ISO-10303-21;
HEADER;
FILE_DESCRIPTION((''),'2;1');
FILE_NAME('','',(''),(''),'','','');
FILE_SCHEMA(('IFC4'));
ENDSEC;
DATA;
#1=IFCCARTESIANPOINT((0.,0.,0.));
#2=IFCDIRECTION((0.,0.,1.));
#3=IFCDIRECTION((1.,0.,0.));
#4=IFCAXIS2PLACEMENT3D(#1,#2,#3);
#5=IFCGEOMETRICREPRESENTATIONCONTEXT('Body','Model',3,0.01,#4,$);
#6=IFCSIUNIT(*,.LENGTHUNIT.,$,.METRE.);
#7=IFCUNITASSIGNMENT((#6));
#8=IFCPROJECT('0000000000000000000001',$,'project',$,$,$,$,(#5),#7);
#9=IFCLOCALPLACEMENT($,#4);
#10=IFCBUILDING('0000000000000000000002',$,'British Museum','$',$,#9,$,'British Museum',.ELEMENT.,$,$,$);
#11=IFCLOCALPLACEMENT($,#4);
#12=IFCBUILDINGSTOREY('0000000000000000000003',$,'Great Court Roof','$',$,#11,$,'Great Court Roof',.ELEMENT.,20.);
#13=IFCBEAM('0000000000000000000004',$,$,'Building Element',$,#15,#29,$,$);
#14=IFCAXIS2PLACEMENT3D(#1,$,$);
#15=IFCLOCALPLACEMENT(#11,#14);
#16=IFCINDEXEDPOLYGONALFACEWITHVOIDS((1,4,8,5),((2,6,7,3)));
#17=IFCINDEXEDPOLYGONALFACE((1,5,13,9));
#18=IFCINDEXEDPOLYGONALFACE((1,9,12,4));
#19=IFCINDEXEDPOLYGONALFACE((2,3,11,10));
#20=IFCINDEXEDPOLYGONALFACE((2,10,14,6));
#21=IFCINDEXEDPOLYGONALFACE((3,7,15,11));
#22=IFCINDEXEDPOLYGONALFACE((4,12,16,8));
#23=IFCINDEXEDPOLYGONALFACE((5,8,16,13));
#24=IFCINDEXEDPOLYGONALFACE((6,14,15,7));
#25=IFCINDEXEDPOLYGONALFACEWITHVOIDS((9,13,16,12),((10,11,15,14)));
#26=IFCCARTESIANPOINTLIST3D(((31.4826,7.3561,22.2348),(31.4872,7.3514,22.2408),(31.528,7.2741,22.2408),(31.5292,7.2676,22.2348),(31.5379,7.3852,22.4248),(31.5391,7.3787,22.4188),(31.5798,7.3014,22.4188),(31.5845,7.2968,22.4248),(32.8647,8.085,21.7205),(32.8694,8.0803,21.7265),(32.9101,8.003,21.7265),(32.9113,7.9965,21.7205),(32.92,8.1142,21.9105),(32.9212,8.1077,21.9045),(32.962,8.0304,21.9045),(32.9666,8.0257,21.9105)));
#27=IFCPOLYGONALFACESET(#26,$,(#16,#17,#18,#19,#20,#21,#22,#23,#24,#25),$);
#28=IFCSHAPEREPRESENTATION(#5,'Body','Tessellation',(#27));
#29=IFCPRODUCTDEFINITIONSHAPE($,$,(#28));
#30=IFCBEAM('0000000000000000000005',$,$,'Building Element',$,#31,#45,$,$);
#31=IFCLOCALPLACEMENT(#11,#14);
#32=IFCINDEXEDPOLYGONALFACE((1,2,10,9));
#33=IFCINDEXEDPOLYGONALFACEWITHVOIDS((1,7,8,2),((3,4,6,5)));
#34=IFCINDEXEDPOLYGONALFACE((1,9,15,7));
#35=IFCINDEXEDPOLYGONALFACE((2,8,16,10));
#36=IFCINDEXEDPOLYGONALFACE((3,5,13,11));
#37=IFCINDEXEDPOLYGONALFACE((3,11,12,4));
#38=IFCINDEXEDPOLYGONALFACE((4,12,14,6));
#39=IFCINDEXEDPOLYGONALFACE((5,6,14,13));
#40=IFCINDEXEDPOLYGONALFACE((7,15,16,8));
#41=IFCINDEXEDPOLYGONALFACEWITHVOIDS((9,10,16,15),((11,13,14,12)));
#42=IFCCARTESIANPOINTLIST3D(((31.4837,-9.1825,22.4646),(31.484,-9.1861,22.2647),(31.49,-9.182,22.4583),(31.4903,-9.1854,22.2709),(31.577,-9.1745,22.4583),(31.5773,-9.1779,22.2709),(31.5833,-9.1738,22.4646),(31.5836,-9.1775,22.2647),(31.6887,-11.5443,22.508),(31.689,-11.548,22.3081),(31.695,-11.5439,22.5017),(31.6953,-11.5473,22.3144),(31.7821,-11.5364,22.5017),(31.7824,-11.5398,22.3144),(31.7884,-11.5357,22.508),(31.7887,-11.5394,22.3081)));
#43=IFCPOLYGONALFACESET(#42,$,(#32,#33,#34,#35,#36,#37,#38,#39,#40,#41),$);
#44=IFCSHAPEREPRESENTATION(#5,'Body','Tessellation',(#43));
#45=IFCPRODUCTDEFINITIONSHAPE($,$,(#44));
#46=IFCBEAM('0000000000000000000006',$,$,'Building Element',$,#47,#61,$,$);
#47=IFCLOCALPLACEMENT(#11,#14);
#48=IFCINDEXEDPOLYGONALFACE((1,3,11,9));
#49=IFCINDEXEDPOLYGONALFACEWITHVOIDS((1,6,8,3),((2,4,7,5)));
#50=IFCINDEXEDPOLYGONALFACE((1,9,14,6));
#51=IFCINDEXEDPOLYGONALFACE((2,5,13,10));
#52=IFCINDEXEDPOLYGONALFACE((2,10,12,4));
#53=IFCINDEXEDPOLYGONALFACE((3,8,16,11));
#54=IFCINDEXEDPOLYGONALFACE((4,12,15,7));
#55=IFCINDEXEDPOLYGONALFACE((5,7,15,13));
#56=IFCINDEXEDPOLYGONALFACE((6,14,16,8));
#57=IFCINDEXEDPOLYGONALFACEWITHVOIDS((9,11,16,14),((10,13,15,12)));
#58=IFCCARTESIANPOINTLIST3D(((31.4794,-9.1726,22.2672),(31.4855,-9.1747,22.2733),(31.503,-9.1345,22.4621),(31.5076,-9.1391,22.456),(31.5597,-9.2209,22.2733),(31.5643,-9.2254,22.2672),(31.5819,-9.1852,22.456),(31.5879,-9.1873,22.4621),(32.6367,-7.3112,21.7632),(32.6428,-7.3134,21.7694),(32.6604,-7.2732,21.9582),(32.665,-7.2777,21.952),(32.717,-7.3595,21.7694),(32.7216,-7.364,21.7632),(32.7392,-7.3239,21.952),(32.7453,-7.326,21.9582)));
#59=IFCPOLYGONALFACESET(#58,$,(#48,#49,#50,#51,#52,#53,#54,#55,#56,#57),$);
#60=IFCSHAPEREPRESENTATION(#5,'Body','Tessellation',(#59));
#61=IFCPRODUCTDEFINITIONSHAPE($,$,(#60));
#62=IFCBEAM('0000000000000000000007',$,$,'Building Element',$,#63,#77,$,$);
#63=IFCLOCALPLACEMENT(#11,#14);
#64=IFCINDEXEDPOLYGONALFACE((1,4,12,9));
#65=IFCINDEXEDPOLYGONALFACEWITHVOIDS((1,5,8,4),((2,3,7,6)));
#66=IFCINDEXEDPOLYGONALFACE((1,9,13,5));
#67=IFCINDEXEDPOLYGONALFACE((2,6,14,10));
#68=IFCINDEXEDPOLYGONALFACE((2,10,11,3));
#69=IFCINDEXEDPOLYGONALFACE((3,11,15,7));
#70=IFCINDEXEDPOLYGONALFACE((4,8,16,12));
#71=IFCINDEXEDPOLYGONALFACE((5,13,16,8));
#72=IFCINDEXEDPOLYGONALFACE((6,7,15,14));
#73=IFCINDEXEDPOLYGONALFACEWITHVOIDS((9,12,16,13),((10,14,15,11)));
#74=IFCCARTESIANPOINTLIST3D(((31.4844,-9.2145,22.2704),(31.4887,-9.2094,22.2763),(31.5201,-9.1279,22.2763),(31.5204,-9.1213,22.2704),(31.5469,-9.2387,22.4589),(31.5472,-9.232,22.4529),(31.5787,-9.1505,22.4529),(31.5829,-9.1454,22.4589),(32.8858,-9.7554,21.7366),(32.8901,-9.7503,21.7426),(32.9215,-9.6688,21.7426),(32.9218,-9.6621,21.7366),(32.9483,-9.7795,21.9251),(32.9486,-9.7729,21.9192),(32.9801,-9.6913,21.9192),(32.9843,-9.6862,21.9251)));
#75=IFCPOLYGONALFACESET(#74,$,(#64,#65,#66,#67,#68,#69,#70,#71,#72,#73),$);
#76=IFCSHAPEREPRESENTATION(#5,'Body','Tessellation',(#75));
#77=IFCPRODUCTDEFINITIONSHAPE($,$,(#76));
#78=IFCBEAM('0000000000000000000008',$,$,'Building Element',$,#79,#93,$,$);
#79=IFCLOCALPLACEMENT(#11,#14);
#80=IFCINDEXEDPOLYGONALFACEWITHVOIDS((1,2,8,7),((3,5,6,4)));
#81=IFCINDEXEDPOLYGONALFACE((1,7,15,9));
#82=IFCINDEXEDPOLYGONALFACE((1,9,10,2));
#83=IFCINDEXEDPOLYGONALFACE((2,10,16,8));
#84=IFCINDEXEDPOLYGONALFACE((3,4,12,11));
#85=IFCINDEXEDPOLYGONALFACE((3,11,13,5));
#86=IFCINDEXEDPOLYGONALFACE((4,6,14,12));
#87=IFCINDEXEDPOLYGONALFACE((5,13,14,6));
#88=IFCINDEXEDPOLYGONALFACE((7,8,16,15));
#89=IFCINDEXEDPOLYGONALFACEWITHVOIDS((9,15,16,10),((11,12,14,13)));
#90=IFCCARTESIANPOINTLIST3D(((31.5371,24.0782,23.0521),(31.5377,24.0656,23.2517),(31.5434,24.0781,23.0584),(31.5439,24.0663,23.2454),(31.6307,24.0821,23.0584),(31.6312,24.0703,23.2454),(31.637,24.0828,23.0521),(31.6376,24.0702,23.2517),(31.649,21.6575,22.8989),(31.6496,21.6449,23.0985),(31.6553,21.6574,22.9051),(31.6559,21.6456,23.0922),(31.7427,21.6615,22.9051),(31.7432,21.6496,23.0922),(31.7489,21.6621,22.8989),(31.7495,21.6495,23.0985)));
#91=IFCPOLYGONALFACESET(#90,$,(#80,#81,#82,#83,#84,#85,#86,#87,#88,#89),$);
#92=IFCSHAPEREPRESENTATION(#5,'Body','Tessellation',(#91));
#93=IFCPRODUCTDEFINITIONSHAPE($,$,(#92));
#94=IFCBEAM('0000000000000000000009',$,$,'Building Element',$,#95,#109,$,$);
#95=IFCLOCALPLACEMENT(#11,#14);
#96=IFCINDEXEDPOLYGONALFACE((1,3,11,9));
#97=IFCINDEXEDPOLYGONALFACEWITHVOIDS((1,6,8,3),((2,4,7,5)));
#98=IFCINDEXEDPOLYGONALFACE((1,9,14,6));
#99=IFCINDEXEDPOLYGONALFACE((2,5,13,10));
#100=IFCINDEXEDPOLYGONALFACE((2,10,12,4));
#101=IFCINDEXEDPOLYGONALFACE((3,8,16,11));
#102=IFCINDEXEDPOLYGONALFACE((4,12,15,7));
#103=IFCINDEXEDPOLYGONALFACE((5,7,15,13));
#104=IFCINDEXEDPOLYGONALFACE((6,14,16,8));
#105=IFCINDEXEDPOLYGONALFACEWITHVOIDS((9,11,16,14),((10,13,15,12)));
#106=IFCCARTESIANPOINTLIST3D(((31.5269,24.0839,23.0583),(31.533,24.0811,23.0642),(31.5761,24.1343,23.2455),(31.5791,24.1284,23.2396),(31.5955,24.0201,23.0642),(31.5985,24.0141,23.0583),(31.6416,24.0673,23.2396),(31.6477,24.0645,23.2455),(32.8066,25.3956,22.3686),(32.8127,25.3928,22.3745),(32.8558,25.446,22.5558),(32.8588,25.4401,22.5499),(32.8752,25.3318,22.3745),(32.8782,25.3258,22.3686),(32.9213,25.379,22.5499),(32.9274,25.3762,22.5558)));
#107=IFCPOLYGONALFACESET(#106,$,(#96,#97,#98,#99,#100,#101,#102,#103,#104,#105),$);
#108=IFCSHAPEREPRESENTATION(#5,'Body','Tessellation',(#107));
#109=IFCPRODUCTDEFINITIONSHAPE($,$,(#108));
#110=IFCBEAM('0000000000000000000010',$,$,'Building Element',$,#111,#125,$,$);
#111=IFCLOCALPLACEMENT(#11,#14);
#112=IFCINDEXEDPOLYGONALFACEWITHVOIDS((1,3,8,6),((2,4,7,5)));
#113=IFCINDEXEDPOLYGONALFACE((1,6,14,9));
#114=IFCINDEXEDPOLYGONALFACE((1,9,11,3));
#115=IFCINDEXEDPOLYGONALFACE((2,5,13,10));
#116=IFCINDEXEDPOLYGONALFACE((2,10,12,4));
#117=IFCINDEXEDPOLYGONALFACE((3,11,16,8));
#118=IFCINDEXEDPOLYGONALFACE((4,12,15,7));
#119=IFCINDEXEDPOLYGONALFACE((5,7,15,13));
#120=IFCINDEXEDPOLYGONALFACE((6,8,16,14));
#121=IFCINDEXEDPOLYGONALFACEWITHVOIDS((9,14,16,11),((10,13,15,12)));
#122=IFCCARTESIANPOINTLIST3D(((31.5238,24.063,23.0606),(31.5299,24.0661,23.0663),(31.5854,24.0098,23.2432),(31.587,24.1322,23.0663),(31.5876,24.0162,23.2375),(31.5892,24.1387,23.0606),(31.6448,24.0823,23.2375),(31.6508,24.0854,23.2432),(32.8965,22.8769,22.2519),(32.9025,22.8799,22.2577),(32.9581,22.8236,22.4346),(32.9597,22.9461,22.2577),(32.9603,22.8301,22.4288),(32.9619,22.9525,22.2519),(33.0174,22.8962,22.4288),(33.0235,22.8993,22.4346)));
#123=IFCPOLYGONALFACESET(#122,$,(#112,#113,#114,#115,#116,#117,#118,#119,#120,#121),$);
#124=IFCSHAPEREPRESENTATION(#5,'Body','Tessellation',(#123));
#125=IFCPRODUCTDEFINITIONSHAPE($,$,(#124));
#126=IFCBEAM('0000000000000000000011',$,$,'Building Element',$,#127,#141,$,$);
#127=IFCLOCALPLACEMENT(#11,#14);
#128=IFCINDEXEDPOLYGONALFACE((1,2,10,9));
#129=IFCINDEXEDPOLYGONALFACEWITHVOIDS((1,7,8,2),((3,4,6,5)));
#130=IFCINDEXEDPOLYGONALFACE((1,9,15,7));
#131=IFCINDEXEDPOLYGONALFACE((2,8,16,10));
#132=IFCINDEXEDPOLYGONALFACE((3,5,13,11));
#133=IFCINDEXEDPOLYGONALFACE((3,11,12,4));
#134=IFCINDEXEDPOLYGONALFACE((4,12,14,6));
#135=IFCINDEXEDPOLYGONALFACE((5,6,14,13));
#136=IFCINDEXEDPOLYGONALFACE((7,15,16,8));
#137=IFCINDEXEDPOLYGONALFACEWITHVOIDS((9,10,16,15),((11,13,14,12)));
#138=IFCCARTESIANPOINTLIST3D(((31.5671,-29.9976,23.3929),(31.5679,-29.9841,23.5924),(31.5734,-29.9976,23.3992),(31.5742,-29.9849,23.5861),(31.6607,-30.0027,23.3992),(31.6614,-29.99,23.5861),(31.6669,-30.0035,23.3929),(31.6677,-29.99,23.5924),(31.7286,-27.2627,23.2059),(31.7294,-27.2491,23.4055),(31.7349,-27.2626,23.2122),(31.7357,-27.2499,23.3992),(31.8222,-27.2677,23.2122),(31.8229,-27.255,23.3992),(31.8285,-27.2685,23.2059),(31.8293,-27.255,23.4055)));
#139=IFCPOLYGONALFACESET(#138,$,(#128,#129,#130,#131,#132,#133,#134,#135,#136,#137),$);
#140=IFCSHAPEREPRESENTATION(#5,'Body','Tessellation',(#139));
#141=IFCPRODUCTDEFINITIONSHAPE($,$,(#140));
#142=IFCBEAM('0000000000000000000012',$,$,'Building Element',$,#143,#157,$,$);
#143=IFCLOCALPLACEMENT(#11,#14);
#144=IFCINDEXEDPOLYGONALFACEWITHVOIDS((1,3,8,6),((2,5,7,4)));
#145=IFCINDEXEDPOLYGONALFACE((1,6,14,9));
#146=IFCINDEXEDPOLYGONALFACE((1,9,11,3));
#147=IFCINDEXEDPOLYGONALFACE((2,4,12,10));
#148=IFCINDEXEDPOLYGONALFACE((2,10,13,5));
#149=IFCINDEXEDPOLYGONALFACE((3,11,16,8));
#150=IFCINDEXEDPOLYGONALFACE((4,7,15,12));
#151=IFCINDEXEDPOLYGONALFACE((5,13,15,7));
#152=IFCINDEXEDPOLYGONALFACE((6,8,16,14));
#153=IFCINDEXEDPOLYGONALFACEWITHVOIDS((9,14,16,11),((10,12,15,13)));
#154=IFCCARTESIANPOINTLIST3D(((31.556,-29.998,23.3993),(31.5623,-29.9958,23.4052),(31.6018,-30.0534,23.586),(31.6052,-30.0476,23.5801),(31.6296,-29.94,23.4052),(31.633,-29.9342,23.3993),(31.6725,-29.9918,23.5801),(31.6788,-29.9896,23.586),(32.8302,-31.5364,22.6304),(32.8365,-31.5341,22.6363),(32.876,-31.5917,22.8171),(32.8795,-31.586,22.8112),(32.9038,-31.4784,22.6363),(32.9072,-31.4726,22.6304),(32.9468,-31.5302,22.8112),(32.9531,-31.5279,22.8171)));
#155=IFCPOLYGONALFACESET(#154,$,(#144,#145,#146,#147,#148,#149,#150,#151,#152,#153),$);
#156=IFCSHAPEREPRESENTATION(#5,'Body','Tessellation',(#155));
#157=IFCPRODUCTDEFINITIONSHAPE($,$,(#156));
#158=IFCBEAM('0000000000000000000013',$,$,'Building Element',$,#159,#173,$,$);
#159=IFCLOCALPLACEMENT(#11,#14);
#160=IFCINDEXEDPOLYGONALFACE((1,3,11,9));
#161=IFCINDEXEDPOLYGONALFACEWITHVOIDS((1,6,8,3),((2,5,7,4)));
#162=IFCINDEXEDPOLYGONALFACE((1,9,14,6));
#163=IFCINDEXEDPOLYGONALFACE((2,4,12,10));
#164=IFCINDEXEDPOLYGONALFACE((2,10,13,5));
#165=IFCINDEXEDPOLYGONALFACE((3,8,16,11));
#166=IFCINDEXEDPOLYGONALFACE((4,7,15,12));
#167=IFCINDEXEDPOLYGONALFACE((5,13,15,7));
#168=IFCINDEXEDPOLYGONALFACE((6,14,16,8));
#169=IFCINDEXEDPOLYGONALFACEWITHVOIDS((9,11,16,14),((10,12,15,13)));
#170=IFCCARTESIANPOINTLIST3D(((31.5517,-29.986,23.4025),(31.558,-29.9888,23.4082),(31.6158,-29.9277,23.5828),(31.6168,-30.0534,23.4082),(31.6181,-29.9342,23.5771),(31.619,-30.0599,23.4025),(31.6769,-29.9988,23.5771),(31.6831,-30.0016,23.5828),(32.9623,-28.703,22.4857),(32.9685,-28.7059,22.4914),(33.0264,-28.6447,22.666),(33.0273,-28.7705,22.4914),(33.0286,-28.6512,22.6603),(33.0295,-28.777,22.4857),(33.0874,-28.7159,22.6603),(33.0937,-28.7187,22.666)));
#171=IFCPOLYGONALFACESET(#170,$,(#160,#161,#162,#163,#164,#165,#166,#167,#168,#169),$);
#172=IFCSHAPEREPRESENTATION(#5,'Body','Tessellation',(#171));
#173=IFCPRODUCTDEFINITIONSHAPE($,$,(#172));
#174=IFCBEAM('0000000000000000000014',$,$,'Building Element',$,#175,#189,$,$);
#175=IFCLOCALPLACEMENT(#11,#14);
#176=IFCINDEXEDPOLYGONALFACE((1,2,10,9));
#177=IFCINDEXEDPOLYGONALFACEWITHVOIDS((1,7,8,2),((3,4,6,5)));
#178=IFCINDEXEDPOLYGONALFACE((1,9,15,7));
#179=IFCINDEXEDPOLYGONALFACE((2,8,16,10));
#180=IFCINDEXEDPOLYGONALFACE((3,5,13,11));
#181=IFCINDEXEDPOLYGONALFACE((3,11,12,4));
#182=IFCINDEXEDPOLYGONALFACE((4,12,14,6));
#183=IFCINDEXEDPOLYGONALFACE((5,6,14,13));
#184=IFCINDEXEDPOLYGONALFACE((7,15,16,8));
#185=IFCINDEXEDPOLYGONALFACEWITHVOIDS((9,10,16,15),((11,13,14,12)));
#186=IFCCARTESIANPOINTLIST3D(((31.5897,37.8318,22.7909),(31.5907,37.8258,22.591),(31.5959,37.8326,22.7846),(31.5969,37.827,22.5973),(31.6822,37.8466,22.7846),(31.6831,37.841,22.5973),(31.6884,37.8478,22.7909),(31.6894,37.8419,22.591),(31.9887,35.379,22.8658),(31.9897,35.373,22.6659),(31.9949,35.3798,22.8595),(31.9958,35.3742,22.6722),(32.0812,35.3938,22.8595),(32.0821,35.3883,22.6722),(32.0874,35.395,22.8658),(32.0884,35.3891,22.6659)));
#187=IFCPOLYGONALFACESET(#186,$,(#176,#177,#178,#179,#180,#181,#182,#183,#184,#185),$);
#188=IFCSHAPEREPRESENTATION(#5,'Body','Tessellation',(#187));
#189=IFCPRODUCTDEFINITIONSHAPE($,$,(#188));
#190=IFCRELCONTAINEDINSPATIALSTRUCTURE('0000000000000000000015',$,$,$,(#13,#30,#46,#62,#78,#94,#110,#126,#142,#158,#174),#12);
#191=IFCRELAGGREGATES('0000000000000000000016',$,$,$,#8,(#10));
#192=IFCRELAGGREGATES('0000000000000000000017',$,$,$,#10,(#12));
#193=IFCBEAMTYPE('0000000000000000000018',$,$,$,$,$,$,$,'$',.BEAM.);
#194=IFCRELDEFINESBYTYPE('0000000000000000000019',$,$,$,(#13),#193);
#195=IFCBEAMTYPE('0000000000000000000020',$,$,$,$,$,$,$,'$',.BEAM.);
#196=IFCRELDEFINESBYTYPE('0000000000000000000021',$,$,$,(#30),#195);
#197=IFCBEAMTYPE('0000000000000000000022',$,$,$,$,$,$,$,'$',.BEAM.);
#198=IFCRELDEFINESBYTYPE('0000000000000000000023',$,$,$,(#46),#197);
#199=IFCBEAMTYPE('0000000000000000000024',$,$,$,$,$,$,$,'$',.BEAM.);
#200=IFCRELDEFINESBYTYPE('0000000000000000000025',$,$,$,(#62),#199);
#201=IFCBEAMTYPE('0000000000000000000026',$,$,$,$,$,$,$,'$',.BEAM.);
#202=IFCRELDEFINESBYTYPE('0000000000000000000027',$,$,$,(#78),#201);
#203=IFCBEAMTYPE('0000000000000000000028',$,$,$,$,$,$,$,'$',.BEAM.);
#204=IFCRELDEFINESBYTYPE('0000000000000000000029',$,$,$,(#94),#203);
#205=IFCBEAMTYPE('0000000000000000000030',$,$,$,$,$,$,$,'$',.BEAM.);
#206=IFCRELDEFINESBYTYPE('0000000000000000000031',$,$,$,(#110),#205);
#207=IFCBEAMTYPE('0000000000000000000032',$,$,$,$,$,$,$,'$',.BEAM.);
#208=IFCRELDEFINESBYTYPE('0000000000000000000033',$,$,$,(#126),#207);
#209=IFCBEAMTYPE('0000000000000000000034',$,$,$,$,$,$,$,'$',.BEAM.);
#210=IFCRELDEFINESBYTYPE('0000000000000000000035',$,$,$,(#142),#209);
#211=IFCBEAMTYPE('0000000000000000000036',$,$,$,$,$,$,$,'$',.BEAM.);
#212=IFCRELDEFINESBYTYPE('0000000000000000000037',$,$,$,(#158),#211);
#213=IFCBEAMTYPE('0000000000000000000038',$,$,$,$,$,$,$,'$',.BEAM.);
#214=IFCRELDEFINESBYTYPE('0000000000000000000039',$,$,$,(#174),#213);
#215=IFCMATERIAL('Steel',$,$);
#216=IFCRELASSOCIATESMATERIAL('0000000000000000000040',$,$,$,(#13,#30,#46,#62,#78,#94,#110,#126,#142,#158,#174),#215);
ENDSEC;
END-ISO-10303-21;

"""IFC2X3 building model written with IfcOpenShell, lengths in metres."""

from ifc_helpers import new_model, si_unit, frame, origin_with_axes, origin_2d, place, context, project, spatial, hollow_rectangle, extrude, material, type_object, element, save


model = new_model("IFC2X3")

# Units and contexts
model_context = context("Model", 3, precision=0.01, world=origin_with_axes(), identifier="Body")
ifc_project = project(units=[si_unit("LENGTHUNIT", "METRE")], contexts=[model_context])

# Building, storey
building_placement = place(None, origin_with_axes())
building = spatial("IfcBuilding", under=ifc_project, at=building_placement, Name="British Museum", Description="$", LongName="British Museum", CompositionType="ELEMENT")
storey_placement = place(None, origin_with_axes())
storey = spatial("IfcBuildingStorey", under=building, at=storey_placement, Name="Great Court Roof", Description="$", LongName="Great Court Roof", CompositionType="ELEMENT", Elevation=20.0)

# Beams
ifc_material = material(Name="Steel")
beam_type_1 = type_object("IfcBeamType", ElementType="$", PredefinedType="BEAM")
beam_1_placement = place(None, origin_with_axes())
element("IfcBeam", 1, at=beam_1_placement, inside=storey, type_object=beam_type_1, material=ifc_material, Description="Building Element", context=model_context, shape_type="SweptSolid", body=[
    extrude(hollow_rectangle(XDim=0.1, YDim=0.2, WallThickness=0.0063, InnerFilletRadius=0.0, OuterFilletRadius=0.0, at=origin_2d()), frame((31.5335, 7.3264, 22.3298), z_axis=(0.84018, 0.443111, -0.31265), x_axis=(-0.466497, 0.884523, 0.0)), (0.0, 0.0, 1.0), 1.645),
])
beam_type_2 = type_object("IfcBeamType", ElementType="$", PredefinedType="BEAM")
beam_2_placement = place(None, origin_with_axes())
element("IfcBeam", 2, at=beam_2_placement, inside=storey, type_object=beam_type_2, material=ifc_material, Description="Building Element", context=model_context, shape_type="SweptSolid", body=[
    extrude(hollow_rectangle(XDim=0.1, YDim=0.2, WallThickness=0.0063, InnerFilletRadius=0.0, OuterFilletRadius=0.0, at=origin_2d()), frame((31.5337, -9.18, 22.3646), z_axis=(0.086476, -0.996086, 0.018315), x_axis=(0.996253, 0.086491, 0.0)), (0.0, 0.0, 1.0), 2.3712),
])
beam_type_3 = type_object("IfcBeamType", ElementType="$", PredefinedType="BEAM")
beam_3_placement = place(None, origin_with_axes())
element("IfcBeam", 3, at=beam_3_placement, inside=storey, type_object=beam_type_3, material=ifc_material, Description="Building Element", context=model_context, shape_type="SweptSolid", body=[
    extrude(hollow_rectangle(XDim=0.1, YDim=0.2, WallThickness=0.0063, InnerFilletRadius=0.0, OuterFilletRadius=0.0, at=origin_2d()), frame((31.5337, -9.18, 22.3646), z_axis=(0.514608, 0.827629, -0.224073), x_axis=(-0.849223, 0.528034, 0.0)), (0.0, 0.0, 1.0), 2.249),
])
beam_type_4 = type_object("IfcBeamType", ElementType="$", PredefinedType="BEAM")
beam_4_placement = place(None, origin_with_axes())
element("IfcBeam", 4, at=beam_4_placement, inside=storey, type_object=beam_type_4, material=ifc_material, Description="Building Element", context=model_context, shape_type="SweptSolid", body=[
    extrude(hollow_rectangle(XDim=0.1, YDim=0.2, WallThickness=0.0063, InnerFilletRadius=0.0, OuterFilletRadius=0.0, at=origin_2d()), frame((31.5337, -9.18, 22.3646), z_axis=(0.879086, -0.339272, -0.334817), x_axis=(0.360053, 0.932932, 0.0)), (0.0, 0.0, 1.0), 1.5942),
])
beam_type_5 = type_object("IfcBeamType", ElementType="$", PredefinedType="BEAM")
beam_5_placement = place(None, origin_with_axes())
element("IfcBeam", 5, at=beam_5_placement, inside=storey, type_object=beam_type_5, material=ifc_material, Description="Building Element", context=model_context, shape_type="SweptSolid", body=[
    extrude(hollow_rectangle(XDim=0.1, YDim=0.2, WallThickness=0.0063, InnerFilletRadius=0.0, OuterFilletRadius=0.0, at=origin_2d()), frame((31.5873, 24.0742, 23.1519), z_axis=(0.046107, -0.996941, -0.063107), x_axis=(0.998932, 0.046199, 0.0)), (0.0, 0.0, 1.0), 2.4281),
])
beam_type_6 = type_object("IfcBeamType", ElementType="$", PredefinedType="BEAM")
beam_6_placement = place(None, origin_with_axes())
element("IfcBeam", 6, at=beam_6_placement, inside=storey, type_object=beam_type_6, material=ifc_material, Description="Building Element", context=model_context, shape_type="SweptSolid", body=[
    extrude(hollow_rectangle(XDim=0.1, YDim=0.2, WallThickness=0.0063, InnerFilletRadius=0.0, OuterFilletRadius=0.0, at=origin_2d()), frame((31.5873, 24.0742, 23.1519), z_axis=(0.653555, 0.66991, -0.35226), x_axis=(-0.71579, 0.698315, 0.0)), (0.0, 0.0, 1.0), 1.958),
])
beam_type_7 = type_object("IfcBeamType", ElementType="$", PredefinedType="BEAM")
beam_7_placement = place(None, origin_with_axes())
element("IfcBeam", 7, at=beam_7_placement, inside=storey, type_object=beam_type_7, material=ifc_material, Description="Building Element", context=model_context, shape_type="SweptSolid", body=[
    extrude(hollow_rectangle(XDim=0.1, YDim=0.2, WallThickness=0.0063, InnerFilletRadius=0.0, OuterFilletRadius=0.0, at=origin_2d()), frame((31.5873, 24.0742, 23.1519), z_axis=(0.691093, -0.597188, -0.407132), x_axis=(0.65383, 0.756642, 0.0)), (0.0, 0.0, 1.0), 1.9862),
])
beam_type_8 = type_object("IfcBeamType", ElementType="$", PredefinedType="BEAM")
beam_8_placement = place(None, origin_with_axes())
element("IfcBeam", 8, at=beam_8_placement, inside=storey, type_object=beam_type_8, material=ifc_material, Description="Building Element", context=model_context, shape_type="SweptSolid", body=[
    extrude(hollow_rectangle(XDim=0.1, YDim=0.2, WallThickness=0.0063, InnerFilletRadius=0.0, OuterFilletRadius=0.0, at=origin_2d()), frame((31.6174, -29.9938, 23.4926), z_axis=(0.058818, 0.995945, -0.068069), x_axis=(-0.998261, 0.058955, 0.0)), (0.0, 0.0, 1.0), 2.7461),
])
beam_type_9 = type_object("IfcBeamType", ElementType="$", PredefinedType="BEAM")
beam_9_placement = place(None, origin_with_axes())
element("IfcBeam", 9, at=beam_9_placement, inside=storey, type_object=beam_type_9, material=ifc_material, Description="Building Element", context=model_context, shape_type="SweptSolid", body=[
    extrude(hollow_rectangle(XDim=0.1, YDim=0.2, WallThickness=0.0063, InnerFilletRadius=0.0, OuterFilletRadius=0.0, at=origin_2d()), frame((31.6174, -29.9938, 23.4926), z_axis=(0.595309, -0.718724, -0.359225), x_axis=(0.770129, 0.637888, 0.0)), (0.0, 0.0, 1.0), 2.1404),
])
beam_type_10 = type_object("IfcBeamType", ElementType="$", PredefinedType="BEAM")
beam_10_placement = place(None, origin_with_axes())
element("IfcBeam", 10, at=beam_10_placement, inside=storey, type_object=beam_type_10, material=ifc_material, Description="Building Element", context=model_context, shape_type="SweptSolid", body=[
    extrude(hollow_rectangle(XDim=0.1, YDim=0.2, WallThickness=0.0063, InnerFilletRadius=0.0, OuterFilletRadius=0.0, at=origin_2d()), frame((31.6174, -29.9938, 23.4926), z_axis=(0.666717, 0.606395, -0.433328), x_axis=(-0.672848, 0.73978, 0.0)), (0.0, 0.0, 1.0), 2.1156),
])
beam_type_11 = type_object("IfcBeamType", ElementType="$", PredefinedType="BEAM")
beam_11_placement = place(None, origin_with_axes())
element("IfcBeam", 11, at=beam_11_placement, inside=storey, type_object=beam_type_11, material=ifc_material, Description="Building Element", context=model_context, shape_type="SweptSolid", body=[
    extrude(hollow_rectangle(XDim=0.1, YDim=0.2, WallThickness=0.0063, InnerFilletRadius=0.0, OuterFilletRadius=0.0, at=origin_2d()), frame((31.6395, 37.8368, 22.6909), z_axis=(0.160485, -0.986579, 0.030123), x_axis=(0.987026, 0.160558, 0.0)), (0.0, 0.0, 1.0), 2.4861),
])

save(model, "model.ifc")
